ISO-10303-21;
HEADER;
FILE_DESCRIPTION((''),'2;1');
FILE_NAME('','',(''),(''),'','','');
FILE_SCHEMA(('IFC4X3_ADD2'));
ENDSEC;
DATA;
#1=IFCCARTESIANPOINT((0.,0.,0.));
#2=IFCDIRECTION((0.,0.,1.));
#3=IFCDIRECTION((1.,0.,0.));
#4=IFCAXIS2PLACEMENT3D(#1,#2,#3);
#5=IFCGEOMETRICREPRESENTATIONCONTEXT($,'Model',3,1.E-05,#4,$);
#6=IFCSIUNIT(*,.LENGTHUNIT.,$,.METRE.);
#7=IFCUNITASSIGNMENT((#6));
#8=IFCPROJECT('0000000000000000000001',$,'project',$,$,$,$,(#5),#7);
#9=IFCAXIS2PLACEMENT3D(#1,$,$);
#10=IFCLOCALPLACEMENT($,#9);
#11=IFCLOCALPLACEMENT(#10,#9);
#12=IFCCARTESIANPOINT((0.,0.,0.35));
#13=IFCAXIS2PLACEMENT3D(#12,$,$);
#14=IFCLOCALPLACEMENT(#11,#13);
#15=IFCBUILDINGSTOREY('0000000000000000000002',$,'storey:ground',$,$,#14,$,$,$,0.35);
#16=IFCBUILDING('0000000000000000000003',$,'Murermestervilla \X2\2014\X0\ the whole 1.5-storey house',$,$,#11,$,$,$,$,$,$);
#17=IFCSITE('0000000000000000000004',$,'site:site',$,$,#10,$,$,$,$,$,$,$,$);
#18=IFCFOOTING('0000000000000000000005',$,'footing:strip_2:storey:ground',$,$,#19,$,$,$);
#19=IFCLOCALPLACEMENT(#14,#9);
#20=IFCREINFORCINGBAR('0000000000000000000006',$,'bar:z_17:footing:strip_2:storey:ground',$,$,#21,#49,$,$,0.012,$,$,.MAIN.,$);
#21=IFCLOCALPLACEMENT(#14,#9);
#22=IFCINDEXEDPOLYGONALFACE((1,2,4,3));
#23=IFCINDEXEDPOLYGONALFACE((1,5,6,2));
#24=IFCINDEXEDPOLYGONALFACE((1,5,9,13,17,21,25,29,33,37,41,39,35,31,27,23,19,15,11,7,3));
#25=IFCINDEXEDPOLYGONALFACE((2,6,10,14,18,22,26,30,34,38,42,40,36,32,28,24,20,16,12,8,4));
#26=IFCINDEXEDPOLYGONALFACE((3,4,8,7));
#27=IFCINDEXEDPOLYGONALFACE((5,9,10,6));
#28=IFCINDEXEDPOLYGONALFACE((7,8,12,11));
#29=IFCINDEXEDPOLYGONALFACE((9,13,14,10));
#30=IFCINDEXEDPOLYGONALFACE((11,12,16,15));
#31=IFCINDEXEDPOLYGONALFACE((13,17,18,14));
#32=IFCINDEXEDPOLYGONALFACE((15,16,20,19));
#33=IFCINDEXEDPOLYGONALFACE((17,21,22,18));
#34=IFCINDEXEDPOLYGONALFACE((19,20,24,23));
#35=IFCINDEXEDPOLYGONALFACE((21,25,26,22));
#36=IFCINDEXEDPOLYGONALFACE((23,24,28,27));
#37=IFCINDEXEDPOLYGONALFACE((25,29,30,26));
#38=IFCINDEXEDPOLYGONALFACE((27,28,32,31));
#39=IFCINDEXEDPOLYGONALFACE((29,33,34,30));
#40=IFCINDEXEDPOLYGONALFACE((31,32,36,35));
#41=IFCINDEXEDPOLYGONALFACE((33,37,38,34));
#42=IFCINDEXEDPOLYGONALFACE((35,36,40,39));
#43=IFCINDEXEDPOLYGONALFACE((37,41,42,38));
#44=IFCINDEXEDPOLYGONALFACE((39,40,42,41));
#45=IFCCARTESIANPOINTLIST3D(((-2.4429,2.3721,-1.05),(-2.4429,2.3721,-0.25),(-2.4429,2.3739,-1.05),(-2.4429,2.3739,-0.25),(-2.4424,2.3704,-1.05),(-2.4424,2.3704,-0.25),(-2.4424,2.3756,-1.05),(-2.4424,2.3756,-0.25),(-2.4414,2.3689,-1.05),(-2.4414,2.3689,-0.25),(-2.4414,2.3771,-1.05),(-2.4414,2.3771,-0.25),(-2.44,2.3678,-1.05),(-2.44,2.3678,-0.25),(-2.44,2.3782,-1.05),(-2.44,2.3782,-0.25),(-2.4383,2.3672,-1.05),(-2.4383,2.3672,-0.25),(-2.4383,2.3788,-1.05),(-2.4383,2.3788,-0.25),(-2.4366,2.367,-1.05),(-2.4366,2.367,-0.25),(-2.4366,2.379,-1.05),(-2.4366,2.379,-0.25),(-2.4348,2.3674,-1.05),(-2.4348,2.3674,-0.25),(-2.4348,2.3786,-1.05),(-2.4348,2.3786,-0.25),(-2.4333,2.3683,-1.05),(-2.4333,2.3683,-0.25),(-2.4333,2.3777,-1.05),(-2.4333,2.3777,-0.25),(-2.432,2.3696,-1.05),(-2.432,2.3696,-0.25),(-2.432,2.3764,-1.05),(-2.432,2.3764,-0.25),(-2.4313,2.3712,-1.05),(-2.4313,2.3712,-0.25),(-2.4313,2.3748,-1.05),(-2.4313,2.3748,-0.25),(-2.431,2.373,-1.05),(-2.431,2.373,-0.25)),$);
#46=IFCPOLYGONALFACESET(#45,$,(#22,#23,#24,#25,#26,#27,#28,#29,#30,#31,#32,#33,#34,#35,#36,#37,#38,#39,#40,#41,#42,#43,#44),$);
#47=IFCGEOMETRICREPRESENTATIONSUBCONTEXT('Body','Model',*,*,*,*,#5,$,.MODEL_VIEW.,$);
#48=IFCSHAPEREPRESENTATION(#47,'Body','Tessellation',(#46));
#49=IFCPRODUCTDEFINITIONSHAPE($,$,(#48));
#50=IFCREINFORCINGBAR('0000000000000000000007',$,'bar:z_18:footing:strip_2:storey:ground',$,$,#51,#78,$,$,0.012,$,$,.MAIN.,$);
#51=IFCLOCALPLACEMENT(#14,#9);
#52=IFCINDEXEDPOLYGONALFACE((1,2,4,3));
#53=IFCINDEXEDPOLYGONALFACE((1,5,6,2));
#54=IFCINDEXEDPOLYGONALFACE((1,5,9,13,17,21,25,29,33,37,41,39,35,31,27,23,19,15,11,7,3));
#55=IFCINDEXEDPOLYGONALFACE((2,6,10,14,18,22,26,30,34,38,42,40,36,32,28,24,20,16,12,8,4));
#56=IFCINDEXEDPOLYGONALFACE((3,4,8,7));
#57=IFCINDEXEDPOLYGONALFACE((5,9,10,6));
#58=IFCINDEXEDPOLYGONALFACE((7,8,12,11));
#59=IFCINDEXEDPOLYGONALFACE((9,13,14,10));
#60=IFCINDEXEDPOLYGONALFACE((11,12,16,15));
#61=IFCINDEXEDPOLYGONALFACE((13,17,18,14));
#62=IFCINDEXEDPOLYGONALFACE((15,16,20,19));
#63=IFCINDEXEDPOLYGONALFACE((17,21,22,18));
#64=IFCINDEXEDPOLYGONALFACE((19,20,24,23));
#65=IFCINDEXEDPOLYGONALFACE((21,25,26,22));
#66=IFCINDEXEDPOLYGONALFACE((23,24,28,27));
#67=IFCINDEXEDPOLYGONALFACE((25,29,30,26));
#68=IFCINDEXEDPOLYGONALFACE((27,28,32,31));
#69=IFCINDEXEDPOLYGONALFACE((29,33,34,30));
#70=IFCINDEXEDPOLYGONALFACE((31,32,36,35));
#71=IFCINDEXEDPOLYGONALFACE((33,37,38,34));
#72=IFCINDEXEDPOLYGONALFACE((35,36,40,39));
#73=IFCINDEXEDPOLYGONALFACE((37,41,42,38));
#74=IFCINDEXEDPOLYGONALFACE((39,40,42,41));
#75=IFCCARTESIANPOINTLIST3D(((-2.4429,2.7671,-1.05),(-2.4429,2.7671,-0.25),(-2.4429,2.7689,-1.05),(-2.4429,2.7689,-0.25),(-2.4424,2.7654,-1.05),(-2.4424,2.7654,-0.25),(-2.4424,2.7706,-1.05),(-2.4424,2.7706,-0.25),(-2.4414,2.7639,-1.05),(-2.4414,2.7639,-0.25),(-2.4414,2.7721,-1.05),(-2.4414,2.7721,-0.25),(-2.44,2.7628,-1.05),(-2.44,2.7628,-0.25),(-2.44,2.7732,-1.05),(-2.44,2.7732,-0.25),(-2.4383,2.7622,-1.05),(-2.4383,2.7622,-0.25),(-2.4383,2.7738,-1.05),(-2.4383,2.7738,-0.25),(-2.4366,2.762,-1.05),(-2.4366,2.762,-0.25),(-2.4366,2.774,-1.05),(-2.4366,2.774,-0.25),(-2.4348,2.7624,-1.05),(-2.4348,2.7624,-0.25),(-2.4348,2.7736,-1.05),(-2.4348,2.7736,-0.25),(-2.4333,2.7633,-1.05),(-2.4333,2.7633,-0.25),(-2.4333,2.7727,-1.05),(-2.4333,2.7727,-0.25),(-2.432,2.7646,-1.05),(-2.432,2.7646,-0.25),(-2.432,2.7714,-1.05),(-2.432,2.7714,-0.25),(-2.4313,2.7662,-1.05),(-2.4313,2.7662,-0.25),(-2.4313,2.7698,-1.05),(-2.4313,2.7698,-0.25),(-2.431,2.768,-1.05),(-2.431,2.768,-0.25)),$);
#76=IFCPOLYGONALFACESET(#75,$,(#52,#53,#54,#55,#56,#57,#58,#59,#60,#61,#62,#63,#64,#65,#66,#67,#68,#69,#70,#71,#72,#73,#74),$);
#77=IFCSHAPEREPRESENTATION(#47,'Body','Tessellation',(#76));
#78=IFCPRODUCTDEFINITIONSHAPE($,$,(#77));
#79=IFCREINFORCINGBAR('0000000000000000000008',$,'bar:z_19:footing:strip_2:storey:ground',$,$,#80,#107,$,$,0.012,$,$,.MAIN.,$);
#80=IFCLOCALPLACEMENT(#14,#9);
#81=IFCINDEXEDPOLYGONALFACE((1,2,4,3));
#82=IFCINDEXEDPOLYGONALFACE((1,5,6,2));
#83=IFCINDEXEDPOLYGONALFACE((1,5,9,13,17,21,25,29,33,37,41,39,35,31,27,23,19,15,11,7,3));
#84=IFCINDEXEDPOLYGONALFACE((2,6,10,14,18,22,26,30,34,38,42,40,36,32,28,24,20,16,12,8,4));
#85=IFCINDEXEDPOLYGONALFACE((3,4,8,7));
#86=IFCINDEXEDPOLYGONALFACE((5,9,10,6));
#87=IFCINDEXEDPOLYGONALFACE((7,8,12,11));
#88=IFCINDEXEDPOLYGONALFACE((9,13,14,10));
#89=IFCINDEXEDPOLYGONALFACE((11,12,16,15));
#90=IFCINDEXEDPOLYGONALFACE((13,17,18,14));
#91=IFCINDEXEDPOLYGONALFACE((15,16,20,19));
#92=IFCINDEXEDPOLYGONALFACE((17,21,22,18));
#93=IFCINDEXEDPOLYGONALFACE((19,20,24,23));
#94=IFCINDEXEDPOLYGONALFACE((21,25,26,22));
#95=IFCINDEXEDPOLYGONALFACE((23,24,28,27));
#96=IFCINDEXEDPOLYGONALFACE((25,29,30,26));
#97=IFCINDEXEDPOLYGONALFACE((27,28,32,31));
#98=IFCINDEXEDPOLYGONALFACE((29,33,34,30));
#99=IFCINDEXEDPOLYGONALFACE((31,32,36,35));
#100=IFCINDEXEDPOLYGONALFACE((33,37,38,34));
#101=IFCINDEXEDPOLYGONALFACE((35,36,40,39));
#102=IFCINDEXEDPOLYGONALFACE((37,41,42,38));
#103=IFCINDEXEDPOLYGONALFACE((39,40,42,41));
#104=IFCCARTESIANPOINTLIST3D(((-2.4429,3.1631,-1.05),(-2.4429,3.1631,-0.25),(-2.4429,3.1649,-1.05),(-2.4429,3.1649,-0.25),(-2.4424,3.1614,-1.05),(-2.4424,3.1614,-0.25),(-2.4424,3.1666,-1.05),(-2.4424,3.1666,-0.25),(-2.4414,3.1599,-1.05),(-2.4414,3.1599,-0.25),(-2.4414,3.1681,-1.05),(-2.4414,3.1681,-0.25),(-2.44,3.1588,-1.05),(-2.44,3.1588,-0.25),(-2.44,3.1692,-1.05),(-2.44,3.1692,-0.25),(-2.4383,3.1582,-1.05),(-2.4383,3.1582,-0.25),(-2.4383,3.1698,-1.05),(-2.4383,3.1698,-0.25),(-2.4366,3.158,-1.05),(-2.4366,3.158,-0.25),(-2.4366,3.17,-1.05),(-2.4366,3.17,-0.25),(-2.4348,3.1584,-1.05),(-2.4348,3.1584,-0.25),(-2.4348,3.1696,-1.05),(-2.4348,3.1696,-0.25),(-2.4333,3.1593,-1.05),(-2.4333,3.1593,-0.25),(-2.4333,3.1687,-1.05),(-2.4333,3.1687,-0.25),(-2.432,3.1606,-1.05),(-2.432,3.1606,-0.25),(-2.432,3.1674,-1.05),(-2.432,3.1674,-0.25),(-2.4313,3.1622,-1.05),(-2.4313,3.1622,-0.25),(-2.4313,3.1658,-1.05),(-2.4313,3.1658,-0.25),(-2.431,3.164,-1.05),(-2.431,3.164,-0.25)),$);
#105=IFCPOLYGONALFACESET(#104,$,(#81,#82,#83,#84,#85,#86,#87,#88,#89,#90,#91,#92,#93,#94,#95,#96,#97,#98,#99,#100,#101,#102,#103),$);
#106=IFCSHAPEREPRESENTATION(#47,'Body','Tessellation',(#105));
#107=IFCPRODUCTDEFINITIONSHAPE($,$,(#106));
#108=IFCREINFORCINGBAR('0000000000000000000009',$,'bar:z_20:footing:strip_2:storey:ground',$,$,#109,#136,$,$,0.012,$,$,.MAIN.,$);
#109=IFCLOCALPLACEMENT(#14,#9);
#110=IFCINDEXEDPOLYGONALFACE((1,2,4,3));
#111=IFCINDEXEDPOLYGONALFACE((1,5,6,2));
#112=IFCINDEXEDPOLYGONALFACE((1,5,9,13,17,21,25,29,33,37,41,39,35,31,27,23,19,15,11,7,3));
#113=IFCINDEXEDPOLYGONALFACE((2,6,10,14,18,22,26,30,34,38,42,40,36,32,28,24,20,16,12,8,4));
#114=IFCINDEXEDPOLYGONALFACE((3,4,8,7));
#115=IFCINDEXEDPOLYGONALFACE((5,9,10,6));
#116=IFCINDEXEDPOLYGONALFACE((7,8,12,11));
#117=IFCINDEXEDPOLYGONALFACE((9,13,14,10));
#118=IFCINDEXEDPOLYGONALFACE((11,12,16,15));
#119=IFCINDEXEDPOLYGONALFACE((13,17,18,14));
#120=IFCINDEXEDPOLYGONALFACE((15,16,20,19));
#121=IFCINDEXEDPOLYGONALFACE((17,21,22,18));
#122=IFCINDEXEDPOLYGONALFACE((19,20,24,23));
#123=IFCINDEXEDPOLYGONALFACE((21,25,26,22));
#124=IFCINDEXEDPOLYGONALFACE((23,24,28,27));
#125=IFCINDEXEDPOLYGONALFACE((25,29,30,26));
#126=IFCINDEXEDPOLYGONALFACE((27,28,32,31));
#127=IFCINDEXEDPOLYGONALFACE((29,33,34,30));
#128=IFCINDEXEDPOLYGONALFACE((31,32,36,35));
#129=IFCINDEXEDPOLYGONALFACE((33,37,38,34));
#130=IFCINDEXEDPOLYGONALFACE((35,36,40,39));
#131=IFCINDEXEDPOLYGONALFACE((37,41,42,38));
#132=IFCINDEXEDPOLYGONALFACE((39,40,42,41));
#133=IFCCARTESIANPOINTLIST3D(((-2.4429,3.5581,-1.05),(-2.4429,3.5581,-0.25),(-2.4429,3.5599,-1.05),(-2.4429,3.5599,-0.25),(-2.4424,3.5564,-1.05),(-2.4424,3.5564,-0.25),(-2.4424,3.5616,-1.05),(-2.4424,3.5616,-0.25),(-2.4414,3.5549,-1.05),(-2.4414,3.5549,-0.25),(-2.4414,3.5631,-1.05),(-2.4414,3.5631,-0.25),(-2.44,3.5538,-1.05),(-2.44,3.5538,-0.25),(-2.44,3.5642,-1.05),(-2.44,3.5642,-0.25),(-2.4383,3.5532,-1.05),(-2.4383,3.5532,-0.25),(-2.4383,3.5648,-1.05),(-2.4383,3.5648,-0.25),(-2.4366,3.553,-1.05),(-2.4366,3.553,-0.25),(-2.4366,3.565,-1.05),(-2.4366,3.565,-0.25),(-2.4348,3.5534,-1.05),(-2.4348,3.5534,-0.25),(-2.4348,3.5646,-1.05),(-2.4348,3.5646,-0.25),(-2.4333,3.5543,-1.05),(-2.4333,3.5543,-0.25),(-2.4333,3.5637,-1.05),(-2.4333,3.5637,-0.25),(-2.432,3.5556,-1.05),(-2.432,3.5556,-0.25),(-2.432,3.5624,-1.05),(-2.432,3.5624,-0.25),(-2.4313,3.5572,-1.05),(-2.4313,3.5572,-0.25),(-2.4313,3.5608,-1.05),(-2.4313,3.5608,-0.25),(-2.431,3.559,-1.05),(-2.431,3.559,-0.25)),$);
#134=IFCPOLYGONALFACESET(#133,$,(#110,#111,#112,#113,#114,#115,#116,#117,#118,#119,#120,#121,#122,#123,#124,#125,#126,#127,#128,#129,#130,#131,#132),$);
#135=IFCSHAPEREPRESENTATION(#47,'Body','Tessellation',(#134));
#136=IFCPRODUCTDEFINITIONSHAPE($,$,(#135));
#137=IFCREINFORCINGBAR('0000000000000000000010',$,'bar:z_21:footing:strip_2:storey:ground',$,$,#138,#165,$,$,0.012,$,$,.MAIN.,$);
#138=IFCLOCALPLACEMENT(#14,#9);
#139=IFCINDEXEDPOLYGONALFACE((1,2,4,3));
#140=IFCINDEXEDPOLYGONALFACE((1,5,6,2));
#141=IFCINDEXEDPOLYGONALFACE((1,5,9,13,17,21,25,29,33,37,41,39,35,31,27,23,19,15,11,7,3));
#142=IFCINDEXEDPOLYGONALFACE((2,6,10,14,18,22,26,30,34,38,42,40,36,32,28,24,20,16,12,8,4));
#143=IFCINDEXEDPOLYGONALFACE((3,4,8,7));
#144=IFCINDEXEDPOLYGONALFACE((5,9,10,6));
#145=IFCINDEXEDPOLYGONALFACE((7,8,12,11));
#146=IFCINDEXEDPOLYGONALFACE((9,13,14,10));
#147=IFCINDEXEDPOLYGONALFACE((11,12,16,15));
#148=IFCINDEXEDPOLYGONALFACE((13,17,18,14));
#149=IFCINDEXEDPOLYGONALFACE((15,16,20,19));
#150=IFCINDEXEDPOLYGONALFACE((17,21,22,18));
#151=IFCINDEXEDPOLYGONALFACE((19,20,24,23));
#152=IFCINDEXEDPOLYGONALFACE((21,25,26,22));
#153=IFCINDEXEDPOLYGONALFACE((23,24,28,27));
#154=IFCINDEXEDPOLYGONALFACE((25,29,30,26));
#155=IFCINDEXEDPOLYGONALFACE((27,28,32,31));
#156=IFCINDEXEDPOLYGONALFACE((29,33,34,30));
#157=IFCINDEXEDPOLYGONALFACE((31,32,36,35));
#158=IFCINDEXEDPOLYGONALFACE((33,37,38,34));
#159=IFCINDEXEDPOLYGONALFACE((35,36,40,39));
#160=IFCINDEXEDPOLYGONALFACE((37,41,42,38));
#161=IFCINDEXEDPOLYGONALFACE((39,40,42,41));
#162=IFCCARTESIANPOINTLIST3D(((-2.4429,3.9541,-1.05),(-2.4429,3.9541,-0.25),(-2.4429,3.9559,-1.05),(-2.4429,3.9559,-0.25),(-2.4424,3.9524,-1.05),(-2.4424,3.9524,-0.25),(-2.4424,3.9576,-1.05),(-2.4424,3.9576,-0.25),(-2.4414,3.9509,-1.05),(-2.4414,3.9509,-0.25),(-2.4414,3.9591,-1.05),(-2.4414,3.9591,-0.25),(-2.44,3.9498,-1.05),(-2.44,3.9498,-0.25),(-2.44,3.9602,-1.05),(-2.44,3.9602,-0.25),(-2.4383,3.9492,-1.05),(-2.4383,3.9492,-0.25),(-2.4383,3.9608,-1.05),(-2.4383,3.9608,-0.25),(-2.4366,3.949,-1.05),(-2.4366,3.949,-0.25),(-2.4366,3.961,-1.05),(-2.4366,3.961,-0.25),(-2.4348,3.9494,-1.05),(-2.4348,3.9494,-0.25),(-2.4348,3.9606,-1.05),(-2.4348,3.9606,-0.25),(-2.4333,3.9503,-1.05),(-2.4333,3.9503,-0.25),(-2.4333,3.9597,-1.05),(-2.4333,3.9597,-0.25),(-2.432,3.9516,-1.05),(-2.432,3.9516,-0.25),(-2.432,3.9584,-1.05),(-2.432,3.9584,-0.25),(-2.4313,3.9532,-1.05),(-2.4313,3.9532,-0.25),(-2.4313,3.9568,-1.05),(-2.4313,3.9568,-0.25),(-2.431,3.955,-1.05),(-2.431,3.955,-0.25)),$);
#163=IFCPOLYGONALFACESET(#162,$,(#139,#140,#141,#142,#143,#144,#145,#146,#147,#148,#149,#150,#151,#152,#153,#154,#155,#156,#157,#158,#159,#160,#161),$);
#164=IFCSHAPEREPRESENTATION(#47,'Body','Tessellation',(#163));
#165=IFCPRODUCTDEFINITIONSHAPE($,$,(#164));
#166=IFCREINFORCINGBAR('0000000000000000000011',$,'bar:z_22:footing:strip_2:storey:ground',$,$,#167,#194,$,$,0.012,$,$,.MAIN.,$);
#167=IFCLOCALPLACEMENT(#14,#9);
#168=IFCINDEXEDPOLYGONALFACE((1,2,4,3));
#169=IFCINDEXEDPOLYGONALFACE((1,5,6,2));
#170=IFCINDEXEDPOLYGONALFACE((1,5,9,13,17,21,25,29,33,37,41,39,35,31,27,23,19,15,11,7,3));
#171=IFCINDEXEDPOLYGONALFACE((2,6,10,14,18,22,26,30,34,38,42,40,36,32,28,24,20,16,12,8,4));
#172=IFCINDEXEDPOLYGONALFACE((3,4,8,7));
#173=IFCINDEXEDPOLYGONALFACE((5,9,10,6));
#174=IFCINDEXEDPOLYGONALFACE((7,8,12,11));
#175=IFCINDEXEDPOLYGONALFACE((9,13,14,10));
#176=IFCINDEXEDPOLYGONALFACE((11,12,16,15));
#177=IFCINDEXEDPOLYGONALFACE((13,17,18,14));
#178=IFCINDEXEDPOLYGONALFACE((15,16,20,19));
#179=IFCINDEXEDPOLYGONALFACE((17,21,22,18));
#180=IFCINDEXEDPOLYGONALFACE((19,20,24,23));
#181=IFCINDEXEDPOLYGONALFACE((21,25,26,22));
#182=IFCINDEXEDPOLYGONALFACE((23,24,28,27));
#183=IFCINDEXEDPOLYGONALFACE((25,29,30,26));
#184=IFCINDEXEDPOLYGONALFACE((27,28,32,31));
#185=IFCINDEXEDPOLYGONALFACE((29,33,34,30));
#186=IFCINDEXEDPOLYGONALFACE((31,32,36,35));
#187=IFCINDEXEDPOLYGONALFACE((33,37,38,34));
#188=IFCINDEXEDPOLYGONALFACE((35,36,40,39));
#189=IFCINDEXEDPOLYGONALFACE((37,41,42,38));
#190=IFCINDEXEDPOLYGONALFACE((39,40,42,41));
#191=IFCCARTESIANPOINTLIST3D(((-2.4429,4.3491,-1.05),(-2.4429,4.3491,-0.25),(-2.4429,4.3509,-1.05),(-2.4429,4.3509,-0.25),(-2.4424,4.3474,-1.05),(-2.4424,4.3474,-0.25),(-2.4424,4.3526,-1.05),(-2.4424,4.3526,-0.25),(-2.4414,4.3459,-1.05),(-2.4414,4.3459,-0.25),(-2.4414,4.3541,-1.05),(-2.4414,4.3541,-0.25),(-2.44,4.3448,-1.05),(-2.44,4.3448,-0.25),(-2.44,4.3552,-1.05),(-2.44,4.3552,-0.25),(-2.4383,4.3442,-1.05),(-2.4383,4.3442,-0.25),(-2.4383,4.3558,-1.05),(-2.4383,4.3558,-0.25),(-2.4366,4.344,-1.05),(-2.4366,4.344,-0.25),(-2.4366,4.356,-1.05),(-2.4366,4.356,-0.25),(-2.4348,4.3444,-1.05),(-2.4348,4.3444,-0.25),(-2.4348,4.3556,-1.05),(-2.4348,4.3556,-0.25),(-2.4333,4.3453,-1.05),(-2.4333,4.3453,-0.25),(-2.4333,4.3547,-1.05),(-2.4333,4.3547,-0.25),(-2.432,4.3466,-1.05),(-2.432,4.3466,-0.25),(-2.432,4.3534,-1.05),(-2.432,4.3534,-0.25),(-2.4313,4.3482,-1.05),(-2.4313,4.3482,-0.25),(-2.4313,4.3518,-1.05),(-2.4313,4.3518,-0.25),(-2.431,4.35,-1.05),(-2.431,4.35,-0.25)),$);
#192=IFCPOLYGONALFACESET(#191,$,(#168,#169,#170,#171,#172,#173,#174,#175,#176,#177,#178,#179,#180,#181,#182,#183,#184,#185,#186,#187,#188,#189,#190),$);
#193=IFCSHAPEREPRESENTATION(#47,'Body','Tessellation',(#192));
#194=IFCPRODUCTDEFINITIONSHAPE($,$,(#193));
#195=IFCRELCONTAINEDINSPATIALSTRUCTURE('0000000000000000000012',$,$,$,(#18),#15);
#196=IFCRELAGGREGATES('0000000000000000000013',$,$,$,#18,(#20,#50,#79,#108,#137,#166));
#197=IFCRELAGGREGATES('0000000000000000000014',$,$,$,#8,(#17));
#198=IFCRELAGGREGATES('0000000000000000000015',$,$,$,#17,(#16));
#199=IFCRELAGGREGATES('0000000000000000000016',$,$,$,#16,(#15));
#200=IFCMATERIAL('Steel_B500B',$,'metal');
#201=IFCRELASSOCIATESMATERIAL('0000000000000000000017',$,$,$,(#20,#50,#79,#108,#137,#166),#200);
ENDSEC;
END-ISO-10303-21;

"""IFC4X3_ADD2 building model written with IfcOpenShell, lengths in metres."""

from ifc_helpers import new_model, entity, si_unit, frame, origin, origin_with_axes, place, context, subcontext, project, spatial, material, element, aggregate, save


model = new_model("IFC4X3_ADD2")

# Units and contexts
model_context = context("Model", 3, precision=1e-05, world=origin_with_axes())
body_context = subcontext(model_context, "Body", "Model", "MODEL_VIEW")
ifc_project = project(units=[si_unit("LENGTHUNIT", "METRE")], contexts=[model_context])

# Site, building, storey
placement_1 = place(None, origin())
site = spatial("IfcSite", under=ifc_project, at=placement_1, Name="site:site")
building_placement = place(placement_1, origin())
building = spatial("IfcBuilding", under=site, at=building_placement, Name="Murermestervilla — the whole 1.5-storey house")
storey_placement = place(building_placement, frame((0.0, 0.0, 0.35)))
storey = spatial("IfcBuildingStorey", under=building, at=storey_placement, Name="storey:ground", Elevation=0.35)

# Footing, reinforcing bars
placement_2 = place(storey_placement, frame((0.0, 0.0, -0.35)))
footing_1 = element("IfcFooting", 1, at=placement_2, inside=storey, Name="footing:strip_2:storey:ground")
ifc_material = material(Name="Steel_B500B", Category="metal")
reinforcing_bar_1 = element("IfcReinforcingBar", 2, at=placement_1, material=ifc_material, Name="bar:z_17:footing:strip_2:storey:ground", NominalDiameter=0.012, PredefinedType="MAIN", context=body_context, shape_type="AdvancedSweptSolid", body=[
    entity("IfcSweptDiskSolid", entity("IfcPolyline", [entity("IfcCartesianPoint", [-2.437, 2.373, -0.7]), entity("IfcCartesianPoint", [-2.437, 2.373, 0.1])]), 0.006),
])
reinforcing_bar_2 = element("IfcReinforcingBar", 3, at=placement_1, material=ifc_material, Name="bar:z_18:footing:strip_2:storey:ground", NominalDiameter=0.012, PredefinedType="MAIN", context=body_context, shape_type="AdvancedSweptSolid", body=[
    entity("IfcSweptDiskSolid", entity("IfcPolyline", [entity("IfcCartesianPoint", [-2.437, 2.768, -0.7]), entity("IfcCartesianPoint", [-2.437, 2.768, 0.1])]), 0.006),
])
reinforcing_bar_3 = element("IfcReinforcingBar", 4, at=placement_1, material=ifc_material, Name="bar:z_19:footing:strip_2:storey:ground", NominalDiameter=0.012, PredefinedType="MAIN", context=body_context, shape_type="AdvancedSweptSolid", body=[
    entity("IfcSweptDiskSolid", entity("IfcPolyline", [entity("IfcCartesianPoint", [-2.437, 3.164, -0.7]), entity("IfcCartesianPoint", [-2.437, 3.164, 0.1])]), 0.006),
])
reinforcing_bar_4 = element("IfcReinforcingBar", 5, at=placement_1, material=ifc_material, Name="bar:z_20:footing:strip_2:storey:ground", NominalDiameter=0.012, PredefinedType="MAIN", context=body_context, shape_type="AdvancedSweptSolid", body=[
    entity("IfcSweptDiskSolid", entity("IfcPolyline", [entity("IfcCartesianPoint", [-2.437, 3.559, -0.7]), entity("IfcCartesianPoint", [-2.437, 3.559, 0.1])]), 0.006),
])
reinforcing_bar_5 = element("IfcReinforcingBar", 6, at=placement_1, material=ifc_material, Name="bar:z_21:footing:strip_2:storey:ground", NominalDiameter=0.012, PredefinedType="MAIN", context=body_context, shape_type="AdvancedSweptSolid", body=[
    entity("IfcSweptDiskSolid", entity("IfcPolyline", [entity("IfcCartesianPoint", [-2.437, 3.955, -0.7]), entity("IfcCartesianPoint", [-2.437, 3.955, 0.1])]), 0.006),
])
reinforcing_bar_6 = element("IfcReinforcingBar", 7, at=placement_1, material=ifc_material, Name="bar:z_22:footing:strip_2:storey:ground", NominalDiameter=0.012, PredefinedType="MAIN", context=body_context, shape_type="AdvancedSweptSolid", body=[
    entity("IfcSweptDiskSolid", entity("IfcPolyline", [entity("IfcCartesianPoint", [-2.437, 4.35, -0.7]), entity("IfcCartesianPoint", [-2.437, 4.35, 0.1])]), 0.006),
])
aggregate(footing_1, [reinforcing_bar_1, reinforcing_bar_2, reinforcing_bar_3, reinforcing_bar_4, reinforcing_bar_5, reinforcing_bar_6])

save(model, "model.ifc")
